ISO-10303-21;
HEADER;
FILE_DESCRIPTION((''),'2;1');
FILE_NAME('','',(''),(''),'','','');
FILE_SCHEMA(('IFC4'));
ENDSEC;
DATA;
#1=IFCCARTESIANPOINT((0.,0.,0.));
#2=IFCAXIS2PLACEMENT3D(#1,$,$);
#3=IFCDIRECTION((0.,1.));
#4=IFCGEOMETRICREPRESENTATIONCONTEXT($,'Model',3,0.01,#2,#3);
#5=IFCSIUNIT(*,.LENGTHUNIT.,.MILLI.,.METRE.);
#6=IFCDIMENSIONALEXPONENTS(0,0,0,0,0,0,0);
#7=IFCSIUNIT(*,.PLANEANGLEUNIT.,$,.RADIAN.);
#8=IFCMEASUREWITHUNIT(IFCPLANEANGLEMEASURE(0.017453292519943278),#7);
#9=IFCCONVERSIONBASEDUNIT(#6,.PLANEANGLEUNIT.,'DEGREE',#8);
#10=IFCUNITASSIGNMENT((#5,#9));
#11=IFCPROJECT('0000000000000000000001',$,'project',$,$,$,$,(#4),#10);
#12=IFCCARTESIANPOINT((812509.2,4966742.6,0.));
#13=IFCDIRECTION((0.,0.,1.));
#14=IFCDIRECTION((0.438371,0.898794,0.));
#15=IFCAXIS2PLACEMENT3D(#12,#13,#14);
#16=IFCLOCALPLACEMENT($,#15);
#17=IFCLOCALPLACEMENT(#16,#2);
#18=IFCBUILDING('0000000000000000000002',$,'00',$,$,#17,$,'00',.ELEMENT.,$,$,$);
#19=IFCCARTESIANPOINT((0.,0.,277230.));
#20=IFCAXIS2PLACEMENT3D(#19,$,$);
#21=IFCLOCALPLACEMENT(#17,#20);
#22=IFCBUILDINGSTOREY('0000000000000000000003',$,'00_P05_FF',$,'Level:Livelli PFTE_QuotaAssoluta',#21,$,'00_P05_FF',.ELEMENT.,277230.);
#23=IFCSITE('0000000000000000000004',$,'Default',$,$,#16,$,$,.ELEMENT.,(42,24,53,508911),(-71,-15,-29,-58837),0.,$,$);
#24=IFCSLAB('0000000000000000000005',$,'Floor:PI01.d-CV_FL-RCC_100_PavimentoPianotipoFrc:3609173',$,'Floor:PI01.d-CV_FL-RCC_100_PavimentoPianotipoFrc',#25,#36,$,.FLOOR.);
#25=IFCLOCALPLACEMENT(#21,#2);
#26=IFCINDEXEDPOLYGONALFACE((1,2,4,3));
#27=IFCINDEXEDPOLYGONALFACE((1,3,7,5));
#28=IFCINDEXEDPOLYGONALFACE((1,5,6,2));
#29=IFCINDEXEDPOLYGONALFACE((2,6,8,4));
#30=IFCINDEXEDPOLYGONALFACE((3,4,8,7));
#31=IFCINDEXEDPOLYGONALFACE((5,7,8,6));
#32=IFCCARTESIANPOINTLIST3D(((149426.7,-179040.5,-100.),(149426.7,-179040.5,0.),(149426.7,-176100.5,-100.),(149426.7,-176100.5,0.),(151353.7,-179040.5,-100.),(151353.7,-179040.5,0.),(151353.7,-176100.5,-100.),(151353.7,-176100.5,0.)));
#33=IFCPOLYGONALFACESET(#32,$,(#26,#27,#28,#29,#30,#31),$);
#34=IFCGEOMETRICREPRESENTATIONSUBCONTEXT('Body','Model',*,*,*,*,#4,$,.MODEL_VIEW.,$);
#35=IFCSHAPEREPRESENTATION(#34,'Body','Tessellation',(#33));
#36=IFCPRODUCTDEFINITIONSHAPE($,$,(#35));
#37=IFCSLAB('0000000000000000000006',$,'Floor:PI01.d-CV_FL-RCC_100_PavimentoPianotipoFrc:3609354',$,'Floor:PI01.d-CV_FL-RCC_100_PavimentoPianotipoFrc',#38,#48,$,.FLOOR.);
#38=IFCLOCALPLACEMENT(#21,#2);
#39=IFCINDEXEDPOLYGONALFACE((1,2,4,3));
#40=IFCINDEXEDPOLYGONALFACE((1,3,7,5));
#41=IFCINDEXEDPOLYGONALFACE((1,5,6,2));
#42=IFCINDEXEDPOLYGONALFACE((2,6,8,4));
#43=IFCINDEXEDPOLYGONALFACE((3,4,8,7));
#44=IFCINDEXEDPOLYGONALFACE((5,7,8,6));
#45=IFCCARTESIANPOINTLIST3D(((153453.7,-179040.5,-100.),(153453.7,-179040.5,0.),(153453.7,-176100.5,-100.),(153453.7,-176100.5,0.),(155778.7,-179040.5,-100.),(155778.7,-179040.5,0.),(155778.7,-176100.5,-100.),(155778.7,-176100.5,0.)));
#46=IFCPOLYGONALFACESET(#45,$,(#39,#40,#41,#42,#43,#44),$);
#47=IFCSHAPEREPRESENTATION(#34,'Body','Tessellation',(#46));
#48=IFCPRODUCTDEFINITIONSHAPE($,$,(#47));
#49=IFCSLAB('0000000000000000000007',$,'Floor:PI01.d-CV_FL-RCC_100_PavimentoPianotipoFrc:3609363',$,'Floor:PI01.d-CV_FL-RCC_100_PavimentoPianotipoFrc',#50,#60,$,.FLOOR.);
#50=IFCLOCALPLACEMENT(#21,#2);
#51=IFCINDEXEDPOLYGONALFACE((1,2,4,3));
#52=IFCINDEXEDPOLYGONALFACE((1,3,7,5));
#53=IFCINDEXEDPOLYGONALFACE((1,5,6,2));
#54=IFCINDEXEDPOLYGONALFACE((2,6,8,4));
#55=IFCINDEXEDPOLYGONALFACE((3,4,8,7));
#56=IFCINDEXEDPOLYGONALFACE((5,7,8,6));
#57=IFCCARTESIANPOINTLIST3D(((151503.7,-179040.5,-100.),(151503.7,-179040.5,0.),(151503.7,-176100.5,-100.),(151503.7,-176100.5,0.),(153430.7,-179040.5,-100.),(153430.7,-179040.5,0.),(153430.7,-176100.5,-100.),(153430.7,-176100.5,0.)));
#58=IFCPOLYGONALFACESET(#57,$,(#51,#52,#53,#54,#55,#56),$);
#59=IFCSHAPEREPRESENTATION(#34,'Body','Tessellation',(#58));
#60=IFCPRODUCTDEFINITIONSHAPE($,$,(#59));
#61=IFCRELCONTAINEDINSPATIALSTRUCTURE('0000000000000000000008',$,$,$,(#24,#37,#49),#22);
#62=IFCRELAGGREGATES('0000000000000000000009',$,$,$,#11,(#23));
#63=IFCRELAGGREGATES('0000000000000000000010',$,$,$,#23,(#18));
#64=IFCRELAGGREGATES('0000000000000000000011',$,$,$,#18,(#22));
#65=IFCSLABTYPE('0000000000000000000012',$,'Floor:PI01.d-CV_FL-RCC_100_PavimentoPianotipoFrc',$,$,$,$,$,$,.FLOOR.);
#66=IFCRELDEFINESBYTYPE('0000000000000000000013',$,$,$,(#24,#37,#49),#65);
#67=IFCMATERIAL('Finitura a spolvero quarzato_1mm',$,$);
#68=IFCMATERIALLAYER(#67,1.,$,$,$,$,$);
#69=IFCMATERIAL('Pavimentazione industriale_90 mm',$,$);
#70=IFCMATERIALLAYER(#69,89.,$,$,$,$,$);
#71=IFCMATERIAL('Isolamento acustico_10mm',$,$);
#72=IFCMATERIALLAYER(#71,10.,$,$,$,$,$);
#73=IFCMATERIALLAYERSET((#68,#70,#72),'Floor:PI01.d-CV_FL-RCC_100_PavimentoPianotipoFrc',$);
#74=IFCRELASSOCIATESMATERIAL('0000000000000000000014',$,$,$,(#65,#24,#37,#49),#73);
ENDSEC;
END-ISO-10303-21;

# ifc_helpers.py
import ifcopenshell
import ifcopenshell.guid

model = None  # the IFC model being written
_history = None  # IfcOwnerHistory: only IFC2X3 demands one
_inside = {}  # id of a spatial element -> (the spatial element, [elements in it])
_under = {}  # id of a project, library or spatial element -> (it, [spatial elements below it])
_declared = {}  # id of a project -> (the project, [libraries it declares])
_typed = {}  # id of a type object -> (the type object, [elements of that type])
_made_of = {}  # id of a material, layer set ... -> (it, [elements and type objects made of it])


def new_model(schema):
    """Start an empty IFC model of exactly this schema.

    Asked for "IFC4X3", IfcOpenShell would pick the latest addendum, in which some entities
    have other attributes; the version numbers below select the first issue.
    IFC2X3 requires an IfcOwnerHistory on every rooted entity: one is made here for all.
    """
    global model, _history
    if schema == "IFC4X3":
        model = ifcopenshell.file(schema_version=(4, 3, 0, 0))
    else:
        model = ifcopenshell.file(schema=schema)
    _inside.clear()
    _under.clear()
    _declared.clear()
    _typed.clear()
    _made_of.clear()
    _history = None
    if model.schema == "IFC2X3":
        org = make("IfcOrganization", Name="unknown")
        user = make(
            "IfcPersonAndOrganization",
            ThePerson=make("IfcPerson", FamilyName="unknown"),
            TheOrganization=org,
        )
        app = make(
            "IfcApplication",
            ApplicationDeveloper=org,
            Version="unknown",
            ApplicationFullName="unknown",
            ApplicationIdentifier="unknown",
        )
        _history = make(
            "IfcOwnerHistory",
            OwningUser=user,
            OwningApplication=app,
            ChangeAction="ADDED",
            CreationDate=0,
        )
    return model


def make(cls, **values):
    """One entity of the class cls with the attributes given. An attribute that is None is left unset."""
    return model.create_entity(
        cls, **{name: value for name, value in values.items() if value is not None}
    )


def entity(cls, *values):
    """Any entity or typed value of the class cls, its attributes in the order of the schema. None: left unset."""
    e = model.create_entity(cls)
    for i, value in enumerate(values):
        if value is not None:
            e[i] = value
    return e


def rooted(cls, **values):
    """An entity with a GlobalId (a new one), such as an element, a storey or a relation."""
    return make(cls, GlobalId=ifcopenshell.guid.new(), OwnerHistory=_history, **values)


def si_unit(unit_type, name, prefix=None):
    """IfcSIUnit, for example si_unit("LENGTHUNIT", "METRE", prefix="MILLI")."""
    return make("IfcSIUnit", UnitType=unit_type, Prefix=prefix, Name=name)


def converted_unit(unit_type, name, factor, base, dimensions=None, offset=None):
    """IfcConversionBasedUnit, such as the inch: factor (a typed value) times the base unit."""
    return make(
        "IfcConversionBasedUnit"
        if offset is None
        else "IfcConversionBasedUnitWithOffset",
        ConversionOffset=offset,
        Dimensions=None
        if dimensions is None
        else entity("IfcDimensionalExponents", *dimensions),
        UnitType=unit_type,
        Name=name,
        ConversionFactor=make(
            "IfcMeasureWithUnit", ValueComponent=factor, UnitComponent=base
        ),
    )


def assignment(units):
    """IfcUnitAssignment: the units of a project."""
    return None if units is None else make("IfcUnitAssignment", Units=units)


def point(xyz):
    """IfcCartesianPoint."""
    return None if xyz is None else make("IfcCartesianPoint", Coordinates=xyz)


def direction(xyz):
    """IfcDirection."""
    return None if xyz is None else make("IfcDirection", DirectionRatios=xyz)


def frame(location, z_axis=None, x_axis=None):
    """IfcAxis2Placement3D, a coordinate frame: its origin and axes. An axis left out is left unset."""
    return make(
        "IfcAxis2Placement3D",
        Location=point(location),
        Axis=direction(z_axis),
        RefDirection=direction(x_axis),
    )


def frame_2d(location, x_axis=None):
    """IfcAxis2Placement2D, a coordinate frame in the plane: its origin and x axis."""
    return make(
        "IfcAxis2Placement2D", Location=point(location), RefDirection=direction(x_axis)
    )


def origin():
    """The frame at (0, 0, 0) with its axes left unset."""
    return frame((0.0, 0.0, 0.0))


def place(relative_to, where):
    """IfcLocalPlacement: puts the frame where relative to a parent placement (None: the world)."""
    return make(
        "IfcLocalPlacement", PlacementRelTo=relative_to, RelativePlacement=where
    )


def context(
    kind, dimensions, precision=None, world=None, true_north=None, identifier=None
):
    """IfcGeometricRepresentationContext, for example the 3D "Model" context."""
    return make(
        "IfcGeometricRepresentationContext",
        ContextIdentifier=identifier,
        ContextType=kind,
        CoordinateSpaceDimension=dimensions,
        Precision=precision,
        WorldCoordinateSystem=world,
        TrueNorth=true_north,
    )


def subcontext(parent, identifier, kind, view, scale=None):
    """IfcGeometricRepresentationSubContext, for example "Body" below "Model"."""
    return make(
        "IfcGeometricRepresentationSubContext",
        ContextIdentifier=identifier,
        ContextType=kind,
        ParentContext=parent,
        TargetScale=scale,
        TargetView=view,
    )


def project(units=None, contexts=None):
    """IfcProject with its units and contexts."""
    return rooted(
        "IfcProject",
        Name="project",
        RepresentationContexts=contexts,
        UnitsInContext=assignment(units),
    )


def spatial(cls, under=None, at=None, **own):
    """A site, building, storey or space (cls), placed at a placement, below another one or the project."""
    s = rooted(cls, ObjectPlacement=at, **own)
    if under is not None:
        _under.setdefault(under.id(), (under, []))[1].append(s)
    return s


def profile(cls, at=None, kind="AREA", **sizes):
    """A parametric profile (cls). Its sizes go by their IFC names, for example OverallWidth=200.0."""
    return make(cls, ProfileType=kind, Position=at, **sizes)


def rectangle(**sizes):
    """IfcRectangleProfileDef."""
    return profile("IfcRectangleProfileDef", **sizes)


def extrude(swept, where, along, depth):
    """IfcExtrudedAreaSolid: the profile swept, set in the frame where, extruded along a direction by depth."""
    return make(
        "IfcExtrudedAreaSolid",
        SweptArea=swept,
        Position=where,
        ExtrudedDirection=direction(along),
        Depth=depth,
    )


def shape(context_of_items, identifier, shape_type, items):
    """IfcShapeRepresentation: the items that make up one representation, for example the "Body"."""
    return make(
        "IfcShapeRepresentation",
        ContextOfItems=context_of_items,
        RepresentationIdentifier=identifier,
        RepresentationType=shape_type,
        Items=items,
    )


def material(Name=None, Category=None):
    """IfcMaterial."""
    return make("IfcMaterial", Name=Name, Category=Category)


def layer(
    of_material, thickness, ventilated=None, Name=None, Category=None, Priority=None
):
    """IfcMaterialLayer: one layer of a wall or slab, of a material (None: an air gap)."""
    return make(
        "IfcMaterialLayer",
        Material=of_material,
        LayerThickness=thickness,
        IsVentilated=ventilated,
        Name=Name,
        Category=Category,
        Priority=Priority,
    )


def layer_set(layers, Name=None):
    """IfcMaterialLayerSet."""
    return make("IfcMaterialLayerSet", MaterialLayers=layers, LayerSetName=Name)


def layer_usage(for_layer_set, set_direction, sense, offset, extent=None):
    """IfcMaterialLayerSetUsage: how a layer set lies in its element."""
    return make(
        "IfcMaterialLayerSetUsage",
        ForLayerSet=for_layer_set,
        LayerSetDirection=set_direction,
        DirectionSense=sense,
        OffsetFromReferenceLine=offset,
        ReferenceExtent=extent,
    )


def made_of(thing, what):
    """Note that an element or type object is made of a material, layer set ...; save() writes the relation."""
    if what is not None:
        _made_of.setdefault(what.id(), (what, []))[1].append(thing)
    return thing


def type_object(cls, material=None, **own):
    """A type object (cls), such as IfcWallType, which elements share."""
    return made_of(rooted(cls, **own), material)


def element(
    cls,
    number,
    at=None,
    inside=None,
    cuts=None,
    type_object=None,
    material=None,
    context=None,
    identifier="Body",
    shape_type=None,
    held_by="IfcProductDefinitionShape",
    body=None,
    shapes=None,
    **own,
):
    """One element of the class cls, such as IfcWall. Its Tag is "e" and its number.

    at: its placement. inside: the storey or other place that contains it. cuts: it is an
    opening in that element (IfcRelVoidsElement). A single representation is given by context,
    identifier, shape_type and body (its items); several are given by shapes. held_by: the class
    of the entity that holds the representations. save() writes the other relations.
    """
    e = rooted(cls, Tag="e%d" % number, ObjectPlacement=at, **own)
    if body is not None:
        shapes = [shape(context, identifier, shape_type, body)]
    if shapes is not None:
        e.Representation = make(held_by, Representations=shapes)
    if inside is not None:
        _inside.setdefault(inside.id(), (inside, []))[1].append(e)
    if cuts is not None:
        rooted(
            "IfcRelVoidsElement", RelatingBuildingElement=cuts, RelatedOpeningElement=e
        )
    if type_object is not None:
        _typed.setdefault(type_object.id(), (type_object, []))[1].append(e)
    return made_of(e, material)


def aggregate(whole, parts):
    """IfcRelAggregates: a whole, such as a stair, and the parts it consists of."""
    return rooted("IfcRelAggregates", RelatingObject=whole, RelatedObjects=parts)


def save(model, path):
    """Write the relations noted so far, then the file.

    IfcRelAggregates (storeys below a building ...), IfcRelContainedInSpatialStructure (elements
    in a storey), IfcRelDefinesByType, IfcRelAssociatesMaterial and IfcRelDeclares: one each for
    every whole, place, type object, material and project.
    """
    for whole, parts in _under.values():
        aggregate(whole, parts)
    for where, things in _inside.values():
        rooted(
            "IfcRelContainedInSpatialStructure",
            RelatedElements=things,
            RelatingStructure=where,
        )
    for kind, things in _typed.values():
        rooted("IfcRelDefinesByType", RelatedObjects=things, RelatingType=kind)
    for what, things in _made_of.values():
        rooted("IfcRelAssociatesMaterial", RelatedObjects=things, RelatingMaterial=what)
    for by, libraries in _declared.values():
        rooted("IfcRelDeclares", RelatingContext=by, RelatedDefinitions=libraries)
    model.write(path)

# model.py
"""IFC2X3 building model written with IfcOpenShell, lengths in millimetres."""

from ifc_helpers import new_model, entity, si_unit, converted_unit, direction, frame, frame_2d, origin, place, context, subcontext, project, spatial, rectangle, extrude, material, layer, layer_set, layer_usage, type_object, element, save


model = new_model("IFC2X3")

# Units and contexts
model_context = context("Model", 3, precision=0.01, world=origin(), true_north=direction((0.0, 1.0)))
body_context = subcontext(model_context, "Body", "Model", "MODEL_VIEW")
ifc_project = project(units=[si_unit("LENGTHUNIT", "METRE", prefix="MILLI"), converted_unit("PLANEANGLEUNIT", "DEGREE", entity("IfcPlaneAngleMeasure", 0.017453292519943278), si_unit("PLANEANGLEUNIT", "RADIAN"), dimensions=[0, 0, 0, 0, 0, 0, 0])], contexts=[model_context])

# Site, building, storey
site_placement = place(None, frame((812509.2, 4966742.6, 0.0), z_axis=(0.0, 0.0, 1.0), x_axis=(0.438371, 0.898794, 0.0)))
site = spatial("IfcSite", under=ifc_project, at=site_placement, Name="Default", CompositionType="ELEMENT", RefLatitude=(42, 24, 53, 508911), RefLongitude=(-71, -15, -29, -58837), RefElevation=0.0)
building_placement = place(site_placement, origin())
building = spatial("IfcBuilding", under=site, at=building_placement, Name="00", LongName="00", CompositionType="ELEMENT")
storey_placement = place(building_placement, frame((0.0, 0.0, 277230.0)))
storey = spatial("IfcBuildingStorey", under=building, at=storey_placement, Name="00_P05_FF", ObjectType="Level:Livelli PFTE_QuotaAssoluta", LongName="00_P05_FF", CompositionType="ELEMENT", Elevation=277230.0)

# Slabs
ifc_material_1 = material(Name="Isolamento acustico_10mm")
ifc_material_2 = material(Name="Finitura a spolvero quarzato_1mm")
ifc_layer_1 = layer(ifc_material_2, 1.0)
ifc_material_3 = material(Name="Pavimentazione industriale_90 mm")
ifc_layer_2 = layer(ifc_material_3, 89.0)
ifc_layer_3 = layer(ifc_material_1, 10.0)
ifc_layer_set_1 = layer_set([ifc_layer_1, ifc_layer_2, ifc_layer_3], Name="Floor:PI01.d-CV_FL-RCC_100_PavimentoPianotipoFrc")
slab_type_1 = type_object("IfcSlabType", Name="Floor:PI01.d-CV_FL-RCC_100_PavimentoPianotipoFrc", PredefinedType="FLOOR", material=ifc_layer_set_1)
ifc_layer_usage_1 = layer_usage(ifc_layer_set_1, "AXIS3", "POSITIVE", 0.0)
slab_1_placement = place(storey_placement, origin())
element("IfcSlab", 1, at=slab_1_placement, inside=storey, type_object=slab_type_1, material=ifc_layer_usage_1, Name="Floor:PI01.d-CV_FL-RCC_100_PavimentoPianotipoFrc:3609173", ObjectType="Floor:PI01.d-CV_FL-RCC_100_PavimentoPianotipoFrc", PredefinedType="FLOOR", context=body_context, shape_type="SweptSolid", body=[
    extrude(rectangle(XDim=2940.0, YDim=1927.0, at=frame_2d((0.0, 0.0), x_axis=(1.0, 0.0))), frame((150390.2, -177570.5, 0.0), z_axis=(0.0, 0.0, -1.0), x_axis=(0.0, 1.0, 0.0)), (0.0, 0.0, 1.0), 100.0),
])
ifc_layer_usage_2 = layer_usage(ifc_layer_set_1, "AXIS3", "POSITIVE", 0.0)
slab_2_placement = place(storey_placement, origin())
element("IfcSlab", 2, at=slab_2_placement, inside=storey, type_object=slab_type_1, material=ifc_layer_usage_2, Name="Floor:PI01.d-CV_FL-RCC_100_PavimentoPianotipoFrc:3609354", ObjectType="Floor:PI01.d-CV_FL-RCC_100_PavimentoPianotipoFrc", PredefinedType="FLOOR", context=body_context, shape_type="SweptSolid", body=[
    extrude(rectangle(XDim=2940.0, YDim=2325.0, at=frame_2d((0.0, 0.0), x_axis=(1.0, 0.0))), frame((154616.2, -177570.5, 0.0), z_axis=(0.0, 0.0, -1.0), x_axis=(0.0, 1.0, 0.0)), (0.0, 0.0, 1.0), 100.0),
])
ifc_layer_usage_3 = layer_usage(ifc_layer_set_1, "AXIS3", "POSITIVE", 0.0)
slab_3_placement = place(storey_placement, origin())
element("IfcSlab", 3, at=slab_3_placement, inside=storey, type_object=slab_type_1, material=ifc_layer_usage_3, Name="Floor:PI01.d-CV_FL-RCC_100_PavimentoPianotipoFrc:3609363", ObjectType="Floor:PI01.d-CV_FL-RCC_100_PavimentoPianotipoFrc", PredefinedType="FLOOR", context=body_context, shape_type="SweptSolid", body=[
    extrude(rectangle(XDim=2940.0, YDim=1927.0, at=frame_2d((0.0, 0.0), x_axis=(1.0, 0.0))), frame((152467.2, -177570.5, 0.0), z_axis=(0.0, 0.0, -1.0), x_axis=(0.0, 1.0, 0.0)), (0.0, 0.0, 1.0), 100.0),
])

save(model, "model.ifc")
